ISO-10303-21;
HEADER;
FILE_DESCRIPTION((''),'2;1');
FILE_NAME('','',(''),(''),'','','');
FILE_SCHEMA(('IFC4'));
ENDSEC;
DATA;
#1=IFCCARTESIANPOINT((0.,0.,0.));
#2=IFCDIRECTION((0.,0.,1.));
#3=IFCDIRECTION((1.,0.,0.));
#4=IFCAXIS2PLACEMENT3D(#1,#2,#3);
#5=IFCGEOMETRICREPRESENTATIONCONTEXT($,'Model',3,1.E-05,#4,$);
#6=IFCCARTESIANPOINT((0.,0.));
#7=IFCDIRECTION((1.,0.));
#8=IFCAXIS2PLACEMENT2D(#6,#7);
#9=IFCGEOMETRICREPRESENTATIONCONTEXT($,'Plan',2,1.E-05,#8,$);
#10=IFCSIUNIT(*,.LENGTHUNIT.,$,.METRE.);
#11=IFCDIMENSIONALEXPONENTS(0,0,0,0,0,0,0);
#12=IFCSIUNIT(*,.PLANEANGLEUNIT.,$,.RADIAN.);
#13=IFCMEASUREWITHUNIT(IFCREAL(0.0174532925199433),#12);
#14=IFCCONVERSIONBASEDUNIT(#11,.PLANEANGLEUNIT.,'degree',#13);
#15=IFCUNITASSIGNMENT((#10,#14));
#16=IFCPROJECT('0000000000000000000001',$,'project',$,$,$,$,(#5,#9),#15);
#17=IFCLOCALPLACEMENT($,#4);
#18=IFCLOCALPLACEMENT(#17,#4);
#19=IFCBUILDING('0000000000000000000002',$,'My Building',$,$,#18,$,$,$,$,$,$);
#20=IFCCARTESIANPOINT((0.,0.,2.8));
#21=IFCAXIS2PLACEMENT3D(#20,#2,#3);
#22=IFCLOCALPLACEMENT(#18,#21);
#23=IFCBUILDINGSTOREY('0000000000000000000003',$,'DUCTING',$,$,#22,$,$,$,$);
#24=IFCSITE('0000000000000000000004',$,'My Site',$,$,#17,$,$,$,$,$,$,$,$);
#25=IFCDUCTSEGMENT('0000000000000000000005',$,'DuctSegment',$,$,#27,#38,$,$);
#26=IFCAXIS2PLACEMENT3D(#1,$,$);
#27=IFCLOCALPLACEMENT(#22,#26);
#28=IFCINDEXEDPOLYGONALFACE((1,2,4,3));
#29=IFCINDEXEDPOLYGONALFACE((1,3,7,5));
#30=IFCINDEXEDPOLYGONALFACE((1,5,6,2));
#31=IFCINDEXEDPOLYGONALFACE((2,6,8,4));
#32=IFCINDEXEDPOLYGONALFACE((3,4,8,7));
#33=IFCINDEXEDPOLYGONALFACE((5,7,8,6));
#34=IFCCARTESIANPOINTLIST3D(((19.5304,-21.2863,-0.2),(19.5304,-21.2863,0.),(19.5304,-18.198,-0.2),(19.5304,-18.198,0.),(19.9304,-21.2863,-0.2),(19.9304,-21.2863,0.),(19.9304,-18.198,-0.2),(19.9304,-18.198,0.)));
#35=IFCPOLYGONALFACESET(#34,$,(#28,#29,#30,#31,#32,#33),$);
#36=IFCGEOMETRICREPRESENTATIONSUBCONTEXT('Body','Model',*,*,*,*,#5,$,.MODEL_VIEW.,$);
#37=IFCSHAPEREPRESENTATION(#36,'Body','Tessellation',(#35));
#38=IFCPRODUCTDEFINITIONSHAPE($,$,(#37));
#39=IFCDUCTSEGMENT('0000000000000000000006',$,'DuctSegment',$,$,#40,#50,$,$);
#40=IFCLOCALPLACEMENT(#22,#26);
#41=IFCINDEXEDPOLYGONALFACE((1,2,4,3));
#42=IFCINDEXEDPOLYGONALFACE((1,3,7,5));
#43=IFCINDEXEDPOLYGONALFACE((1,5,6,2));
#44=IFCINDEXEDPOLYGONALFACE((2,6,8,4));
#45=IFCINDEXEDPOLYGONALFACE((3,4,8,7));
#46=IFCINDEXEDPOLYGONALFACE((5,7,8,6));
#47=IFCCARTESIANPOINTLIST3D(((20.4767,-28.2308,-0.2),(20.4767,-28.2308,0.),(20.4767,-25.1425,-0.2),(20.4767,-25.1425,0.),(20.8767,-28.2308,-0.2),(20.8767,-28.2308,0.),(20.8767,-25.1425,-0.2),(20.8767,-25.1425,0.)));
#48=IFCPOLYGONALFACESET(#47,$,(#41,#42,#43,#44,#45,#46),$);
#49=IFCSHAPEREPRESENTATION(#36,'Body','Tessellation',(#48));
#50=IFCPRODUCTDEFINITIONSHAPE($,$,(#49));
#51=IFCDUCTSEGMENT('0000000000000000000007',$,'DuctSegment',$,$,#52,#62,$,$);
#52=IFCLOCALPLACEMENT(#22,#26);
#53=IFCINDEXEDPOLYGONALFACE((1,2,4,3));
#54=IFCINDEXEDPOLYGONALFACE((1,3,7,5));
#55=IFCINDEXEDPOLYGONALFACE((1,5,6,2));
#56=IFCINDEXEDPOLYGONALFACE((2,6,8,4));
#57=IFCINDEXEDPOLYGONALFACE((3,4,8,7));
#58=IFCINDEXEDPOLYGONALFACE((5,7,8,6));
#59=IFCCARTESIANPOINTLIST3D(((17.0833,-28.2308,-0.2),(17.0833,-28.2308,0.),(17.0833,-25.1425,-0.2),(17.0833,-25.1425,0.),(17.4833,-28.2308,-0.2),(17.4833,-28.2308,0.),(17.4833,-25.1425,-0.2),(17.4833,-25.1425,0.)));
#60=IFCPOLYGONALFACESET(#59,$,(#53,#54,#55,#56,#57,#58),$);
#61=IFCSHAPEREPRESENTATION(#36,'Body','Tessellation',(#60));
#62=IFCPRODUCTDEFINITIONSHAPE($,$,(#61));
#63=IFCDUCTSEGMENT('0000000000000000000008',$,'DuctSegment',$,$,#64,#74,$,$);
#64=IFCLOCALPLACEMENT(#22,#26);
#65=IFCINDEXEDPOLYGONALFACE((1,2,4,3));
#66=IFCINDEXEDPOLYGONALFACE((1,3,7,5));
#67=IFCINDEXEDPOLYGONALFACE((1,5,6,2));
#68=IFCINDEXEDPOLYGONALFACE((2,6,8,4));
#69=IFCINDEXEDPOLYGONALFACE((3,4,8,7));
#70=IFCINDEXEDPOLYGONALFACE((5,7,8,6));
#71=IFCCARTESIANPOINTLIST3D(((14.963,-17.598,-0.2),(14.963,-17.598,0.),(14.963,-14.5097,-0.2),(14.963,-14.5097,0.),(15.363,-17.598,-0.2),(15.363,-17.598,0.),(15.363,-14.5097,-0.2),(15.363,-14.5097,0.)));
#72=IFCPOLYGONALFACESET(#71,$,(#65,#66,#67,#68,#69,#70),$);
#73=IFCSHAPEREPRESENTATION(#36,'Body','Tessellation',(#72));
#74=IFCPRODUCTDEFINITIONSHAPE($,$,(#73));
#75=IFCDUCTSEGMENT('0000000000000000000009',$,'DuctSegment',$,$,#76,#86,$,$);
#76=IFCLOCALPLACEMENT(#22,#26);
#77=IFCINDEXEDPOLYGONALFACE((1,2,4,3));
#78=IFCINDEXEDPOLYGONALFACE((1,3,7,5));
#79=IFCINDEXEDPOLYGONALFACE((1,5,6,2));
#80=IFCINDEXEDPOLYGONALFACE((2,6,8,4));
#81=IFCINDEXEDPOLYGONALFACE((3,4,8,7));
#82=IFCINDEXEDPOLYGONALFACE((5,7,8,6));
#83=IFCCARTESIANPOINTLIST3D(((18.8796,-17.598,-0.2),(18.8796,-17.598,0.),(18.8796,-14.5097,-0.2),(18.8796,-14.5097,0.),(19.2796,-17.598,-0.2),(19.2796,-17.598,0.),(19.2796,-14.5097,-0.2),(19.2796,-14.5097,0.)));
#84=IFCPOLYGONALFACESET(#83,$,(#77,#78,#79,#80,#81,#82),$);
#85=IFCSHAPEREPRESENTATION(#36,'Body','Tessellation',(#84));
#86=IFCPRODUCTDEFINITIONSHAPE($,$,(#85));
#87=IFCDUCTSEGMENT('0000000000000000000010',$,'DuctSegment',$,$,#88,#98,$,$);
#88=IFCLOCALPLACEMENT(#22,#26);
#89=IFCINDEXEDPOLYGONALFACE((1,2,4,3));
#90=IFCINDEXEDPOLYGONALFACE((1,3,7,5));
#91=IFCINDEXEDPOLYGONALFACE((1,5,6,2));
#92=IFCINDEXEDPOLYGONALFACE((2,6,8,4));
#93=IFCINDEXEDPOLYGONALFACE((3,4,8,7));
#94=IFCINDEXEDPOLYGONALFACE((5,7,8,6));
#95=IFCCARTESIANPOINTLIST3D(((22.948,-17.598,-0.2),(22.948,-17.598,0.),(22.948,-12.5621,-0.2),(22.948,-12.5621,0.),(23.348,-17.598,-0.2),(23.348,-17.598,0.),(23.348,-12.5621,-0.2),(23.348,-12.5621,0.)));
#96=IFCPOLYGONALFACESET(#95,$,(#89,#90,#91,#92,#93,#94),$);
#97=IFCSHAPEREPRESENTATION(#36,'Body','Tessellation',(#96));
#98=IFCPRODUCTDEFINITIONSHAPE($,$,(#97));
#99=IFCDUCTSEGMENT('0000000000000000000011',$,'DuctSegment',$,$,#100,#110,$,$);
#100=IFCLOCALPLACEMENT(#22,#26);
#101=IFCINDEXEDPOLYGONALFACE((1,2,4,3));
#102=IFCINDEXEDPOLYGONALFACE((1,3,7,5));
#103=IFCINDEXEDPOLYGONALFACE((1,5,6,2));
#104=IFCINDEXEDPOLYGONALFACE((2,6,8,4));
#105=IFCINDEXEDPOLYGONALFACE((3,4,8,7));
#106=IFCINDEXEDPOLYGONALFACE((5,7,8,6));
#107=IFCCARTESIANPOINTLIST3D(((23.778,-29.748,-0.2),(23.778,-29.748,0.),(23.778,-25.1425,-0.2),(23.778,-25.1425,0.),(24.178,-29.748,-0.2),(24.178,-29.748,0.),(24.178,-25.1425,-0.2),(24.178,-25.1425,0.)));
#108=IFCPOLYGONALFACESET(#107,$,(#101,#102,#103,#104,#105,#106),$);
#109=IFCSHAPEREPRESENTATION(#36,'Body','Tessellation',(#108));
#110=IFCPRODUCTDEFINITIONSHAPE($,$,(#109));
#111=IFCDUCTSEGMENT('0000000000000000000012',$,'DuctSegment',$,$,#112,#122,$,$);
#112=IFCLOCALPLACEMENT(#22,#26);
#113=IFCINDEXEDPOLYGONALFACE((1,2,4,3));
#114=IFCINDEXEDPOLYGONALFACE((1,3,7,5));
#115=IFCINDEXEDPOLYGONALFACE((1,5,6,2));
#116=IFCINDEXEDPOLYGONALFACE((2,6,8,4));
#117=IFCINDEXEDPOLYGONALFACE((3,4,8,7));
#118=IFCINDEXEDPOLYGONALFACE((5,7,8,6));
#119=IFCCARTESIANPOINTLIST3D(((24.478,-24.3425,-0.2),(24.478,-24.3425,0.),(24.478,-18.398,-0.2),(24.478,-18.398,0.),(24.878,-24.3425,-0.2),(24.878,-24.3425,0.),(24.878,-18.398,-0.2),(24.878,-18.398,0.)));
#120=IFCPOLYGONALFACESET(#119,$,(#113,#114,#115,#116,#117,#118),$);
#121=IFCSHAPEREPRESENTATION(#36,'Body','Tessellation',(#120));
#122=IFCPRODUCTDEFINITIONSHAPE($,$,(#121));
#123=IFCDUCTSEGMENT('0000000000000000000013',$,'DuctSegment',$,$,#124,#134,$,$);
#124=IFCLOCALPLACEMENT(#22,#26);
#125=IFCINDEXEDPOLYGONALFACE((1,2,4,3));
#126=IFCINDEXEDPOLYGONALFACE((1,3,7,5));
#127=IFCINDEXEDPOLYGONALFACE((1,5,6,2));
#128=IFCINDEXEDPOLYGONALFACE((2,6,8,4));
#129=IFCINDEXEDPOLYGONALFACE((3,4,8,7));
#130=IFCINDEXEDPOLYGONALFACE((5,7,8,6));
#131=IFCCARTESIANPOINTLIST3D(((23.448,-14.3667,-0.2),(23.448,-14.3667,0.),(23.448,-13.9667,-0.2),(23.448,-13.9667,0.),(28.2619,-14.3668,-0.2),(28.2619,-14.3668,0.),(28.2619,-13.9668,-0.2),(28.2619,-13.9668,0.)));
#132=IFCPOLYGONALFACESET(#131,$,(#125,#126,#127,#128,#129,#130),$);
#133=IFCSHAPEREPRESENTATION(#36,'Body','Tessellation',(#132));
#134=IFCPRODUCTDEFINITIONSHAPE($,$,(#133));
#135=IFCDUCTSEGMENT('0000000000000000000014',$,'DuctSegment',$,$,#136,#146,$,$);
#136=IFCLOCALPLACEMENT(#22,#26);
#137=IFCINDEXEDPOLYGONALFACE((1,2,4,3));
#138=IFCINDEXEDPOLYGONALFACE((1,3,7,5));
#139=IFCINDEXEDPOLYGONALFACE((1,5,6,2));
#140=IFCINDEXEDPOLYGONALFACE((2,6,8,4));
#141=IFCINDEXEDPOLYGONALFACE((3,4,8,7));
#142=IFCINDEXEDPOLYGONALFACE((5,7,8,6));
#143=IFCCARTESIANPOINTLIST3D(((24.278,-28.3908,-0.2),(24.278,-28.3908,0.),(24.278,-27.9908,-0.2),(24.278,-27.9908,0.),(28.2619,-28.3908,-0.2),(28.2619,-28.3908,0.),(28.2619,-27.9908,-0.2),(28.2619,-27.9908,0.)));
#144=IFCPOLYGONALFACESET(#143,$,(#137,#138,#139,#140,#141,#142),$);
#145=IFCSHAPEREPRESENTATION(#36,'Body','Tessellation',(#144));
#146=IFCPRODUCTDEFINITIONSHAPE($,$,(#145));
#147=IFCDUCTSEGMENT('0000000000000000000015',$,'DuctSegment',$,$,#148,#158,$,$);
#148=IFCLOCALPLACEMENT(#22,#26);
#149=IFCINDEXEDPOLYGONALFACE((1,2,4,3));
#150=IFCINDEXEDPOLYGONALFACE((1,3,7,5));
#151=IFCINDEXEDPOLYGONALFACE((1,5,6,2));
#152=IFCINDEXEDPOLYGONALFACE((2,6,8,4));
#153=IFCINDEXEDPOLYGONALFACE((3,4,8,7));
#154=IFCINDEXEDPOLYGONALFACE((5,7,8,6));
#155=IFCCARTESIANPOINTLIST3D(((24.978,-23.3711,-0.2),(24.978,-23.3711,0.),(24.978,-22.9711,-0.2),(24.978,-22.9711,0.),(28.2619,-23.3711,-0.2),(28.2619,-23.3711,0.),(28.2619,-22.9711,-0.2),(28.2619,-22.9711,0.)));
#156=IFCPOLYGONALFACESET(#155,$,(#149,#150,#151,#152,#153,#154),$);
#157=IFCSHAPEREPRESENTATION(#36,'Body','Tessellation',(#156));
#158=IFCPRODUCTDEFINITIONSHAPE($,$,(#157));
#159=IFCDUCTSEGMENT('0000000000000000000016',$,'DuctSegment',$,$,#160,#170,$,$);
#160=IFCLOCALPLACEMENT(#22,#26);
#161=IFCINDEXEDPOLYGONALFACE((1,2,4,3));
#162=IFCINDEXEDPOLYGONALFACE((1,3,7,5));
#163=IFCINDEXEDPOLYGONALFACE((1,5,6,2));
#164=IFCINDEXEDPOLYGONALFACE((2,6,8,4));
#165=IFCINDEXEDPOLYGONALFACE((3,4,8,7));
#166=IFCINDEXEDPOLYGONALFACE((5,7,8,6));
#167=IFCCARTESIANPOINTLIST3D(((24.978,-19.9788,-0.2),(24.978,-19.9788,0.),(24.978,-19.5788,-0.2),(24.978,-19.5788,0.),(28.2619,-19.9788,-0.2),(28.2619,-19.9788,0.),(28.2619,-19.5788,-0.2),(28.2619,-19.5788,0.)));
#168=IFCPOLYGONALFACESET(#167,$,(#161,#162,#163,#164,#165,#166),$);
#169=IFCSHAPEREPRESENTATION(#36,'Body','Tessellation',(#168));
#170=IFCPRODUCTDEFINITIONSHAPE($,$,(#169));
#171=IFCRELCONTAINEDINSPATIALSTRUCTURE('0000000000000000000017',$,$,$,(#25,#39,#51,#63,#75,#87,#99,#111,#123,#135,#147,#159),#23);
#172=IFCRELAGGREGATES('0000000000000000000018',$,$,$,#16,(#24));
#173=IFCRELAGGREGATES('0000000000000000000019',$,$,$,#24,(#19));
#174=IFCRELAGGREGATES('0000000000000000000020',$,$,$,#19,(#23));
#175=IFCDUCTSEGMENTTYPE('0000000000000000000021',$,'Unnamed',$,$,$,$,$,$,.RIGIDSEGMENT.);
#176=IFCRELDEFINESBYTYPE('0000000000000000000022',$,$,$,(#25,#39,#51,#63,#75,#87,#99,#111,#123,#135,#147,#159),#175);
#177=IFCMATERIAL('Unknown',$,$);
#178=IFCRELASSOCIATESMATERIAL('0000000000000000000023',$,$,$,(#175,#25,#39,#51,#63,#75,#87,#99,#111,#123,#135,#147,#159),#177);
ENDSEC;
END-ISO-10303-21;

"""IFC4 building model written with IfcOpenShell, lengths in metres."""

from ifc_helpers import new_model, entity, si_unit, converted_unit, frame, origin_with_axes, origin_2d_with_axis, place, context, subcontext, project, spatial, rectangle, extrude, material, material_profile, profile_set, profile_usage, type_object, element, save


model = new_model("IFC4")

# Units and contexts
model_context = context("Model", 3, precision=1e-05, world=origin_with_axes())
plan_context = context("Plan", 2, precision=1e-05, world=origin_2d_with_axis())
body_context = subcontext(model_context, "Body", "Model", "MODEL_VIEW")
ifc_project = project(units=[si_unit("LENGTHUNIT", "METRE"), converted_unit("PLANEANGLEUNIT", "degree", entity("IfcReal", 0.0174532925199433), si_unit("PLANEANGLEUNIT", "RADIAN"), dimensions=[0, 0, 0, 0, 0, 0, 0])], contexts=[model_context, plan_context])

# Site, building, storey
site_placement = place(None, origin_with_axes())
site = spatial("IfcSite", under=ifc_project, at=site_placement, Name="My Site")
building_placement = place(site_placement, origin_with_axes())
building = spatial("IfcBuilding", under=site, at=building_placement, Name="My Building")
storey_placement = place(building_placement, frame((0.0, 0.0, 2.8), z_axis=(0.0, 0.0, 1.0), x_axis=(1.0, 0.0, 0.0)))
storey = spatial("IfcBuildingStorey", under=building, at=storey_placement, Name="DUCTING")

# Duct segments
ifc_material = material(Name="Unknown")
ifc_material_profile_1 = material_profile(ifc_material, rectangle(XDim=0.4, YDim=0.2))
ifc_profile_set_1 = profile_set([ifc_material_profile_1])
ifc_profile_usage_1 = profile_usage(ifc_profile_set_1, cardinal=5)
duct_segment_type = type_object("IfcDuctSegmentType", Name="Unnamed", PredefinedType="RIGIDSEGMENT", material=ifc_profile_set_1)
duct_segment_1_placement = place(storey_placement, frame((19.7304, -18.198, -0.1), z_axis=(0.0, -1.0, 0.0), x_axis=(1.0, 0.0, 0.0)))
element("IfcDuctSegment", 1, at=duct_segment_1_placement, inside=storey, type_object=duct_segment_type, material=ifc_profile_usage_1, Name="DuctSegment", context=body_context, shape_type="SweptSolid", body=[
    extrude(rectangle(XDim=0.4, YDim=0.2), origin_with_axes(), (0.0, 0.0, 1.0), 3.0883),
])
ifc_profile_usage_2 = profile_usage(ifc_profile_set_1, cardinal=5)
duct_segment_2_placement = place(storey_placement, frame((20.6767, -25.1425, -0.1), z_axis=(0.0, -1.0, 0.0), x_axis=(1.0, 0.0, 0.0)))
element("IfcDuctSegment", 2, at=duct_segment_2_placement, inside=storey, type_object=duct_segment_type, material=ifc_profile_usage_2, Name="DuctSegment", context=body_context, shape_type="SweptSolid", body=[
    extrude(rectangle(XDim=0.4, YDim=0.2), origin_with_axes(), (0.0, 0.0, 1.0), 3.0883),
])
ifc_profile_usage_3 = profile_usage(ifc_profile_set_1, cardinal=5)
duct_segment_3_placement = place(storey_placement, frame((17.2833, -25.1425, -0.1), z_axis=(0.0, -1.0, 0.0), x_axis=(1.0, 0.0, 0.0)))
element("IfcDuctSegment", 3, at=duct_segment_3_placement, inside=storey, type_object=duct_segment_type, material=ifc_profile_usage_3, Name="DuctSegment", context=body_context, shape_type="SweptSolid", body=[
    extrude(rectangle(XDim=0.4, YDim=0.2), origin_with_axes(), (0.0, 0.0, 1.0), 3.0883),
])
ifc_profile_usage_4 = profile_usage(ifc_profile_set_1, cardinal=5)
duct_segment_4_placement = place(storey_placement, frame((15.163, -17.598, -0.1), z_axis=(0.0, 1.0, 0.0), x_axis=(-1.0, 0.0, 0.0)))
element("IfcDuctSegment", 4, at=duct_segment_4_placement, inside=storey, type_object=duct_segment_type, material=ifc_profile_usage_4, Name="DuctSegment", context=body_context, shape_type="SweptSolid", body=[
    extrude(rectangle(XDim=0.4, YDim=0.2), origin_with_axes(), (0.0, 0.0, 1.0), 3.0883),
])
ifc_profile_usage_5 = profile_usage(ifc_profile_set_1, cardinal=5)
duct_segment_5_placement = place(storey_placement, frame((19.0796, -17.598, -0.1), z_axis=(0.0, 1.0, 0.0), x_axis=(-1.0, 0.0, 0.0)))
element("IfcDuctSegment", 5, at=duct_segment_5_placement, inside=storey, type_object=duct_segment_type, material=ifc_profile_usage_5, Name="DuctSegment", context=body_context, shape_type="SweptSolid", body=[
    extrude(rectangle(XDim=0.4, YDim=0.2), origin_with_axes(), (0.0, 0.0, 1.0), 3.0883),
])
ifc_profile_usage_6 = profile_usage(ifc_profile_set_1, cardinal=5)
duct_segment_6_placement = place(storey_placement, frame((23.148, -17.598, -0.1), z_axis=(0.0, 1.0, 0.0), x_axis=(-1.0, 0.0, 0.0)))
element("IfcDuctSegment", 6, at=duct_segment_6_placement, inside=storey, type_object=duct_segment_type, material=ifc_profile_usage_6, Name="DuctSegment", context=body_context, shape_type="SweptSolid", body=[
    extrude(rectangle(XDim=0.4, YDim=0.2), origin_with_axes(), (0.0, 0.0, 1.0), 5.0359),
])
ifc_profile_usage_7 = profile_usage(ifc_profile_set_1, cardinal=5)
duct_segment_7_placement = place(storey_placement, frame((23.978, -29.748, -0.1), z_axis=(0.0, 1.0, 0.0), x_axis=(-1.0, 0.0, 0.0)))
element("IfcDuctSegment", 7, at=duct_segment_7_placement, inside=storey, type_object=duct_segment_type, material=ifc_profile_usage_7, Name="DuctSegment", context=body_context, shape_type="SweptSolid", body=[
    extrude(rectangle(XDim=0.4, YDim=0.2), origin_with_axes(), (0.0, 0.0, 1.0), 4.6055),
])
ifc_profile_usage_8 = profile_usage(ifc_profile_set_1, cardinal=5)
duct_segment_8_placement = place(storey_placement, frame((24.678, -18.398, -0.1), z_axis=(0.0, -1.0, 0.0), x_axis=(1.0, 0.0, 0.0)))
element("IfcDuctSegment", 8, at=duct_segment_8_placement, inside=storey, type_object=duct_segment_type, material=ifc_profile_usage_8, Name="DuctSegment", context=body_context, shape_type="SweptSolid", body=[
    extrude(rectangle(XDim=0.4, YDim=0.2), origin_with_axes(), (0.0, 0.0, 1.0), 5.9445),
])
ifc_profile_usage_9 = profile_usage(ifc_profile_set_1, cardinal=5)
duct_segment_9_placement = place(storey_placement, frame((23.448, -14.1667, -0.1), z_axis=(1.0, 0.0, 0.0), x_axis=(0.0, 1.0, 0.0)))
element("IfcDuctSegment", 9, at=duct_segment_9_placement, inside=storey, type_object=duct_segment_type, material=ifc_profile_usage_9, Name="DuctSegment", context=body_context, shape_type="SweptSolid", body=[
    extrude(rectangle(XDim=0.4, YDim=0.2), origin_with_axes(), (0.0, 0.0, 1.0), 4.8139),
])
ifc_profile_usage_10 = profile_usage(ifc_profile_set_1, cardinal=5)
duct_segment_10_placement = place(storey_placement, frame((24.278, -28.1908, -0.1), z_axis=(1.0, 0.0, 0.0), x_axis=(0.0, 1.0, 0.0)))
element("IfcDuctSegment", 10, at=duct_segment_10_placement, inside=storey, type_object=duct_segment_type, material=ifc_profile_usage_10, Name="DuctSegment", context=body_context, shape_type="SweptSolid", body=[
    extrude(rectangle(XDim=0.4, YDim=0.2), origin_with_axes(), (0.0, 0.0, 1.0), 3.9839),
])
ifc_profile_usage_11 = profile_usage(ifc_profile_set_1, cardinal=5)
duct_segment_11_placement = place(storey_placement, frame((24.978, -23.1711, -0.1), z_axis=(1.0, 0.0, 0.0), x_axis=(0.0, 1.0, 0.0)))
element("IfcDuctSegment", 11, at=duct_segment_11_placement, inside=storey, type_object=duct_segment_type, material=ifc_profile_usage_11, Name="DuctSegment", context=body_context, shape_type="SweptSolid", body=[
    extrude(rectangle(XDim=0.4, YDim=0.2), origin_with_axes(), (0.0, 0.0, 1.0), 3.2839),
])
ifc_profile_usage_12 = profile_usage(ifc_profile_set_1, cardinal=5)
duct_segment_12_placement = place(storey_placement, frame((24.978, -19.7788, -0.1), z_axis=(1.0, 0.0, 0.0), x_axis=(0.0, 1.0, 0.0)))
element("IfcDuctSegment", 12, at=duct_segment_12_placement, inside=storey, type_object=duct_segment_type, material=ifc_profile_usage_12, Name="DuctSegment", context=body_context, shape_type="SweptSolid", body=[
    extrude(rectangle(XDim=0.4, YDim=0.2), origin_with_axes(), (0.0, 0.0, 1.0), 3.2839),
])

save(model, "model.ifc")
